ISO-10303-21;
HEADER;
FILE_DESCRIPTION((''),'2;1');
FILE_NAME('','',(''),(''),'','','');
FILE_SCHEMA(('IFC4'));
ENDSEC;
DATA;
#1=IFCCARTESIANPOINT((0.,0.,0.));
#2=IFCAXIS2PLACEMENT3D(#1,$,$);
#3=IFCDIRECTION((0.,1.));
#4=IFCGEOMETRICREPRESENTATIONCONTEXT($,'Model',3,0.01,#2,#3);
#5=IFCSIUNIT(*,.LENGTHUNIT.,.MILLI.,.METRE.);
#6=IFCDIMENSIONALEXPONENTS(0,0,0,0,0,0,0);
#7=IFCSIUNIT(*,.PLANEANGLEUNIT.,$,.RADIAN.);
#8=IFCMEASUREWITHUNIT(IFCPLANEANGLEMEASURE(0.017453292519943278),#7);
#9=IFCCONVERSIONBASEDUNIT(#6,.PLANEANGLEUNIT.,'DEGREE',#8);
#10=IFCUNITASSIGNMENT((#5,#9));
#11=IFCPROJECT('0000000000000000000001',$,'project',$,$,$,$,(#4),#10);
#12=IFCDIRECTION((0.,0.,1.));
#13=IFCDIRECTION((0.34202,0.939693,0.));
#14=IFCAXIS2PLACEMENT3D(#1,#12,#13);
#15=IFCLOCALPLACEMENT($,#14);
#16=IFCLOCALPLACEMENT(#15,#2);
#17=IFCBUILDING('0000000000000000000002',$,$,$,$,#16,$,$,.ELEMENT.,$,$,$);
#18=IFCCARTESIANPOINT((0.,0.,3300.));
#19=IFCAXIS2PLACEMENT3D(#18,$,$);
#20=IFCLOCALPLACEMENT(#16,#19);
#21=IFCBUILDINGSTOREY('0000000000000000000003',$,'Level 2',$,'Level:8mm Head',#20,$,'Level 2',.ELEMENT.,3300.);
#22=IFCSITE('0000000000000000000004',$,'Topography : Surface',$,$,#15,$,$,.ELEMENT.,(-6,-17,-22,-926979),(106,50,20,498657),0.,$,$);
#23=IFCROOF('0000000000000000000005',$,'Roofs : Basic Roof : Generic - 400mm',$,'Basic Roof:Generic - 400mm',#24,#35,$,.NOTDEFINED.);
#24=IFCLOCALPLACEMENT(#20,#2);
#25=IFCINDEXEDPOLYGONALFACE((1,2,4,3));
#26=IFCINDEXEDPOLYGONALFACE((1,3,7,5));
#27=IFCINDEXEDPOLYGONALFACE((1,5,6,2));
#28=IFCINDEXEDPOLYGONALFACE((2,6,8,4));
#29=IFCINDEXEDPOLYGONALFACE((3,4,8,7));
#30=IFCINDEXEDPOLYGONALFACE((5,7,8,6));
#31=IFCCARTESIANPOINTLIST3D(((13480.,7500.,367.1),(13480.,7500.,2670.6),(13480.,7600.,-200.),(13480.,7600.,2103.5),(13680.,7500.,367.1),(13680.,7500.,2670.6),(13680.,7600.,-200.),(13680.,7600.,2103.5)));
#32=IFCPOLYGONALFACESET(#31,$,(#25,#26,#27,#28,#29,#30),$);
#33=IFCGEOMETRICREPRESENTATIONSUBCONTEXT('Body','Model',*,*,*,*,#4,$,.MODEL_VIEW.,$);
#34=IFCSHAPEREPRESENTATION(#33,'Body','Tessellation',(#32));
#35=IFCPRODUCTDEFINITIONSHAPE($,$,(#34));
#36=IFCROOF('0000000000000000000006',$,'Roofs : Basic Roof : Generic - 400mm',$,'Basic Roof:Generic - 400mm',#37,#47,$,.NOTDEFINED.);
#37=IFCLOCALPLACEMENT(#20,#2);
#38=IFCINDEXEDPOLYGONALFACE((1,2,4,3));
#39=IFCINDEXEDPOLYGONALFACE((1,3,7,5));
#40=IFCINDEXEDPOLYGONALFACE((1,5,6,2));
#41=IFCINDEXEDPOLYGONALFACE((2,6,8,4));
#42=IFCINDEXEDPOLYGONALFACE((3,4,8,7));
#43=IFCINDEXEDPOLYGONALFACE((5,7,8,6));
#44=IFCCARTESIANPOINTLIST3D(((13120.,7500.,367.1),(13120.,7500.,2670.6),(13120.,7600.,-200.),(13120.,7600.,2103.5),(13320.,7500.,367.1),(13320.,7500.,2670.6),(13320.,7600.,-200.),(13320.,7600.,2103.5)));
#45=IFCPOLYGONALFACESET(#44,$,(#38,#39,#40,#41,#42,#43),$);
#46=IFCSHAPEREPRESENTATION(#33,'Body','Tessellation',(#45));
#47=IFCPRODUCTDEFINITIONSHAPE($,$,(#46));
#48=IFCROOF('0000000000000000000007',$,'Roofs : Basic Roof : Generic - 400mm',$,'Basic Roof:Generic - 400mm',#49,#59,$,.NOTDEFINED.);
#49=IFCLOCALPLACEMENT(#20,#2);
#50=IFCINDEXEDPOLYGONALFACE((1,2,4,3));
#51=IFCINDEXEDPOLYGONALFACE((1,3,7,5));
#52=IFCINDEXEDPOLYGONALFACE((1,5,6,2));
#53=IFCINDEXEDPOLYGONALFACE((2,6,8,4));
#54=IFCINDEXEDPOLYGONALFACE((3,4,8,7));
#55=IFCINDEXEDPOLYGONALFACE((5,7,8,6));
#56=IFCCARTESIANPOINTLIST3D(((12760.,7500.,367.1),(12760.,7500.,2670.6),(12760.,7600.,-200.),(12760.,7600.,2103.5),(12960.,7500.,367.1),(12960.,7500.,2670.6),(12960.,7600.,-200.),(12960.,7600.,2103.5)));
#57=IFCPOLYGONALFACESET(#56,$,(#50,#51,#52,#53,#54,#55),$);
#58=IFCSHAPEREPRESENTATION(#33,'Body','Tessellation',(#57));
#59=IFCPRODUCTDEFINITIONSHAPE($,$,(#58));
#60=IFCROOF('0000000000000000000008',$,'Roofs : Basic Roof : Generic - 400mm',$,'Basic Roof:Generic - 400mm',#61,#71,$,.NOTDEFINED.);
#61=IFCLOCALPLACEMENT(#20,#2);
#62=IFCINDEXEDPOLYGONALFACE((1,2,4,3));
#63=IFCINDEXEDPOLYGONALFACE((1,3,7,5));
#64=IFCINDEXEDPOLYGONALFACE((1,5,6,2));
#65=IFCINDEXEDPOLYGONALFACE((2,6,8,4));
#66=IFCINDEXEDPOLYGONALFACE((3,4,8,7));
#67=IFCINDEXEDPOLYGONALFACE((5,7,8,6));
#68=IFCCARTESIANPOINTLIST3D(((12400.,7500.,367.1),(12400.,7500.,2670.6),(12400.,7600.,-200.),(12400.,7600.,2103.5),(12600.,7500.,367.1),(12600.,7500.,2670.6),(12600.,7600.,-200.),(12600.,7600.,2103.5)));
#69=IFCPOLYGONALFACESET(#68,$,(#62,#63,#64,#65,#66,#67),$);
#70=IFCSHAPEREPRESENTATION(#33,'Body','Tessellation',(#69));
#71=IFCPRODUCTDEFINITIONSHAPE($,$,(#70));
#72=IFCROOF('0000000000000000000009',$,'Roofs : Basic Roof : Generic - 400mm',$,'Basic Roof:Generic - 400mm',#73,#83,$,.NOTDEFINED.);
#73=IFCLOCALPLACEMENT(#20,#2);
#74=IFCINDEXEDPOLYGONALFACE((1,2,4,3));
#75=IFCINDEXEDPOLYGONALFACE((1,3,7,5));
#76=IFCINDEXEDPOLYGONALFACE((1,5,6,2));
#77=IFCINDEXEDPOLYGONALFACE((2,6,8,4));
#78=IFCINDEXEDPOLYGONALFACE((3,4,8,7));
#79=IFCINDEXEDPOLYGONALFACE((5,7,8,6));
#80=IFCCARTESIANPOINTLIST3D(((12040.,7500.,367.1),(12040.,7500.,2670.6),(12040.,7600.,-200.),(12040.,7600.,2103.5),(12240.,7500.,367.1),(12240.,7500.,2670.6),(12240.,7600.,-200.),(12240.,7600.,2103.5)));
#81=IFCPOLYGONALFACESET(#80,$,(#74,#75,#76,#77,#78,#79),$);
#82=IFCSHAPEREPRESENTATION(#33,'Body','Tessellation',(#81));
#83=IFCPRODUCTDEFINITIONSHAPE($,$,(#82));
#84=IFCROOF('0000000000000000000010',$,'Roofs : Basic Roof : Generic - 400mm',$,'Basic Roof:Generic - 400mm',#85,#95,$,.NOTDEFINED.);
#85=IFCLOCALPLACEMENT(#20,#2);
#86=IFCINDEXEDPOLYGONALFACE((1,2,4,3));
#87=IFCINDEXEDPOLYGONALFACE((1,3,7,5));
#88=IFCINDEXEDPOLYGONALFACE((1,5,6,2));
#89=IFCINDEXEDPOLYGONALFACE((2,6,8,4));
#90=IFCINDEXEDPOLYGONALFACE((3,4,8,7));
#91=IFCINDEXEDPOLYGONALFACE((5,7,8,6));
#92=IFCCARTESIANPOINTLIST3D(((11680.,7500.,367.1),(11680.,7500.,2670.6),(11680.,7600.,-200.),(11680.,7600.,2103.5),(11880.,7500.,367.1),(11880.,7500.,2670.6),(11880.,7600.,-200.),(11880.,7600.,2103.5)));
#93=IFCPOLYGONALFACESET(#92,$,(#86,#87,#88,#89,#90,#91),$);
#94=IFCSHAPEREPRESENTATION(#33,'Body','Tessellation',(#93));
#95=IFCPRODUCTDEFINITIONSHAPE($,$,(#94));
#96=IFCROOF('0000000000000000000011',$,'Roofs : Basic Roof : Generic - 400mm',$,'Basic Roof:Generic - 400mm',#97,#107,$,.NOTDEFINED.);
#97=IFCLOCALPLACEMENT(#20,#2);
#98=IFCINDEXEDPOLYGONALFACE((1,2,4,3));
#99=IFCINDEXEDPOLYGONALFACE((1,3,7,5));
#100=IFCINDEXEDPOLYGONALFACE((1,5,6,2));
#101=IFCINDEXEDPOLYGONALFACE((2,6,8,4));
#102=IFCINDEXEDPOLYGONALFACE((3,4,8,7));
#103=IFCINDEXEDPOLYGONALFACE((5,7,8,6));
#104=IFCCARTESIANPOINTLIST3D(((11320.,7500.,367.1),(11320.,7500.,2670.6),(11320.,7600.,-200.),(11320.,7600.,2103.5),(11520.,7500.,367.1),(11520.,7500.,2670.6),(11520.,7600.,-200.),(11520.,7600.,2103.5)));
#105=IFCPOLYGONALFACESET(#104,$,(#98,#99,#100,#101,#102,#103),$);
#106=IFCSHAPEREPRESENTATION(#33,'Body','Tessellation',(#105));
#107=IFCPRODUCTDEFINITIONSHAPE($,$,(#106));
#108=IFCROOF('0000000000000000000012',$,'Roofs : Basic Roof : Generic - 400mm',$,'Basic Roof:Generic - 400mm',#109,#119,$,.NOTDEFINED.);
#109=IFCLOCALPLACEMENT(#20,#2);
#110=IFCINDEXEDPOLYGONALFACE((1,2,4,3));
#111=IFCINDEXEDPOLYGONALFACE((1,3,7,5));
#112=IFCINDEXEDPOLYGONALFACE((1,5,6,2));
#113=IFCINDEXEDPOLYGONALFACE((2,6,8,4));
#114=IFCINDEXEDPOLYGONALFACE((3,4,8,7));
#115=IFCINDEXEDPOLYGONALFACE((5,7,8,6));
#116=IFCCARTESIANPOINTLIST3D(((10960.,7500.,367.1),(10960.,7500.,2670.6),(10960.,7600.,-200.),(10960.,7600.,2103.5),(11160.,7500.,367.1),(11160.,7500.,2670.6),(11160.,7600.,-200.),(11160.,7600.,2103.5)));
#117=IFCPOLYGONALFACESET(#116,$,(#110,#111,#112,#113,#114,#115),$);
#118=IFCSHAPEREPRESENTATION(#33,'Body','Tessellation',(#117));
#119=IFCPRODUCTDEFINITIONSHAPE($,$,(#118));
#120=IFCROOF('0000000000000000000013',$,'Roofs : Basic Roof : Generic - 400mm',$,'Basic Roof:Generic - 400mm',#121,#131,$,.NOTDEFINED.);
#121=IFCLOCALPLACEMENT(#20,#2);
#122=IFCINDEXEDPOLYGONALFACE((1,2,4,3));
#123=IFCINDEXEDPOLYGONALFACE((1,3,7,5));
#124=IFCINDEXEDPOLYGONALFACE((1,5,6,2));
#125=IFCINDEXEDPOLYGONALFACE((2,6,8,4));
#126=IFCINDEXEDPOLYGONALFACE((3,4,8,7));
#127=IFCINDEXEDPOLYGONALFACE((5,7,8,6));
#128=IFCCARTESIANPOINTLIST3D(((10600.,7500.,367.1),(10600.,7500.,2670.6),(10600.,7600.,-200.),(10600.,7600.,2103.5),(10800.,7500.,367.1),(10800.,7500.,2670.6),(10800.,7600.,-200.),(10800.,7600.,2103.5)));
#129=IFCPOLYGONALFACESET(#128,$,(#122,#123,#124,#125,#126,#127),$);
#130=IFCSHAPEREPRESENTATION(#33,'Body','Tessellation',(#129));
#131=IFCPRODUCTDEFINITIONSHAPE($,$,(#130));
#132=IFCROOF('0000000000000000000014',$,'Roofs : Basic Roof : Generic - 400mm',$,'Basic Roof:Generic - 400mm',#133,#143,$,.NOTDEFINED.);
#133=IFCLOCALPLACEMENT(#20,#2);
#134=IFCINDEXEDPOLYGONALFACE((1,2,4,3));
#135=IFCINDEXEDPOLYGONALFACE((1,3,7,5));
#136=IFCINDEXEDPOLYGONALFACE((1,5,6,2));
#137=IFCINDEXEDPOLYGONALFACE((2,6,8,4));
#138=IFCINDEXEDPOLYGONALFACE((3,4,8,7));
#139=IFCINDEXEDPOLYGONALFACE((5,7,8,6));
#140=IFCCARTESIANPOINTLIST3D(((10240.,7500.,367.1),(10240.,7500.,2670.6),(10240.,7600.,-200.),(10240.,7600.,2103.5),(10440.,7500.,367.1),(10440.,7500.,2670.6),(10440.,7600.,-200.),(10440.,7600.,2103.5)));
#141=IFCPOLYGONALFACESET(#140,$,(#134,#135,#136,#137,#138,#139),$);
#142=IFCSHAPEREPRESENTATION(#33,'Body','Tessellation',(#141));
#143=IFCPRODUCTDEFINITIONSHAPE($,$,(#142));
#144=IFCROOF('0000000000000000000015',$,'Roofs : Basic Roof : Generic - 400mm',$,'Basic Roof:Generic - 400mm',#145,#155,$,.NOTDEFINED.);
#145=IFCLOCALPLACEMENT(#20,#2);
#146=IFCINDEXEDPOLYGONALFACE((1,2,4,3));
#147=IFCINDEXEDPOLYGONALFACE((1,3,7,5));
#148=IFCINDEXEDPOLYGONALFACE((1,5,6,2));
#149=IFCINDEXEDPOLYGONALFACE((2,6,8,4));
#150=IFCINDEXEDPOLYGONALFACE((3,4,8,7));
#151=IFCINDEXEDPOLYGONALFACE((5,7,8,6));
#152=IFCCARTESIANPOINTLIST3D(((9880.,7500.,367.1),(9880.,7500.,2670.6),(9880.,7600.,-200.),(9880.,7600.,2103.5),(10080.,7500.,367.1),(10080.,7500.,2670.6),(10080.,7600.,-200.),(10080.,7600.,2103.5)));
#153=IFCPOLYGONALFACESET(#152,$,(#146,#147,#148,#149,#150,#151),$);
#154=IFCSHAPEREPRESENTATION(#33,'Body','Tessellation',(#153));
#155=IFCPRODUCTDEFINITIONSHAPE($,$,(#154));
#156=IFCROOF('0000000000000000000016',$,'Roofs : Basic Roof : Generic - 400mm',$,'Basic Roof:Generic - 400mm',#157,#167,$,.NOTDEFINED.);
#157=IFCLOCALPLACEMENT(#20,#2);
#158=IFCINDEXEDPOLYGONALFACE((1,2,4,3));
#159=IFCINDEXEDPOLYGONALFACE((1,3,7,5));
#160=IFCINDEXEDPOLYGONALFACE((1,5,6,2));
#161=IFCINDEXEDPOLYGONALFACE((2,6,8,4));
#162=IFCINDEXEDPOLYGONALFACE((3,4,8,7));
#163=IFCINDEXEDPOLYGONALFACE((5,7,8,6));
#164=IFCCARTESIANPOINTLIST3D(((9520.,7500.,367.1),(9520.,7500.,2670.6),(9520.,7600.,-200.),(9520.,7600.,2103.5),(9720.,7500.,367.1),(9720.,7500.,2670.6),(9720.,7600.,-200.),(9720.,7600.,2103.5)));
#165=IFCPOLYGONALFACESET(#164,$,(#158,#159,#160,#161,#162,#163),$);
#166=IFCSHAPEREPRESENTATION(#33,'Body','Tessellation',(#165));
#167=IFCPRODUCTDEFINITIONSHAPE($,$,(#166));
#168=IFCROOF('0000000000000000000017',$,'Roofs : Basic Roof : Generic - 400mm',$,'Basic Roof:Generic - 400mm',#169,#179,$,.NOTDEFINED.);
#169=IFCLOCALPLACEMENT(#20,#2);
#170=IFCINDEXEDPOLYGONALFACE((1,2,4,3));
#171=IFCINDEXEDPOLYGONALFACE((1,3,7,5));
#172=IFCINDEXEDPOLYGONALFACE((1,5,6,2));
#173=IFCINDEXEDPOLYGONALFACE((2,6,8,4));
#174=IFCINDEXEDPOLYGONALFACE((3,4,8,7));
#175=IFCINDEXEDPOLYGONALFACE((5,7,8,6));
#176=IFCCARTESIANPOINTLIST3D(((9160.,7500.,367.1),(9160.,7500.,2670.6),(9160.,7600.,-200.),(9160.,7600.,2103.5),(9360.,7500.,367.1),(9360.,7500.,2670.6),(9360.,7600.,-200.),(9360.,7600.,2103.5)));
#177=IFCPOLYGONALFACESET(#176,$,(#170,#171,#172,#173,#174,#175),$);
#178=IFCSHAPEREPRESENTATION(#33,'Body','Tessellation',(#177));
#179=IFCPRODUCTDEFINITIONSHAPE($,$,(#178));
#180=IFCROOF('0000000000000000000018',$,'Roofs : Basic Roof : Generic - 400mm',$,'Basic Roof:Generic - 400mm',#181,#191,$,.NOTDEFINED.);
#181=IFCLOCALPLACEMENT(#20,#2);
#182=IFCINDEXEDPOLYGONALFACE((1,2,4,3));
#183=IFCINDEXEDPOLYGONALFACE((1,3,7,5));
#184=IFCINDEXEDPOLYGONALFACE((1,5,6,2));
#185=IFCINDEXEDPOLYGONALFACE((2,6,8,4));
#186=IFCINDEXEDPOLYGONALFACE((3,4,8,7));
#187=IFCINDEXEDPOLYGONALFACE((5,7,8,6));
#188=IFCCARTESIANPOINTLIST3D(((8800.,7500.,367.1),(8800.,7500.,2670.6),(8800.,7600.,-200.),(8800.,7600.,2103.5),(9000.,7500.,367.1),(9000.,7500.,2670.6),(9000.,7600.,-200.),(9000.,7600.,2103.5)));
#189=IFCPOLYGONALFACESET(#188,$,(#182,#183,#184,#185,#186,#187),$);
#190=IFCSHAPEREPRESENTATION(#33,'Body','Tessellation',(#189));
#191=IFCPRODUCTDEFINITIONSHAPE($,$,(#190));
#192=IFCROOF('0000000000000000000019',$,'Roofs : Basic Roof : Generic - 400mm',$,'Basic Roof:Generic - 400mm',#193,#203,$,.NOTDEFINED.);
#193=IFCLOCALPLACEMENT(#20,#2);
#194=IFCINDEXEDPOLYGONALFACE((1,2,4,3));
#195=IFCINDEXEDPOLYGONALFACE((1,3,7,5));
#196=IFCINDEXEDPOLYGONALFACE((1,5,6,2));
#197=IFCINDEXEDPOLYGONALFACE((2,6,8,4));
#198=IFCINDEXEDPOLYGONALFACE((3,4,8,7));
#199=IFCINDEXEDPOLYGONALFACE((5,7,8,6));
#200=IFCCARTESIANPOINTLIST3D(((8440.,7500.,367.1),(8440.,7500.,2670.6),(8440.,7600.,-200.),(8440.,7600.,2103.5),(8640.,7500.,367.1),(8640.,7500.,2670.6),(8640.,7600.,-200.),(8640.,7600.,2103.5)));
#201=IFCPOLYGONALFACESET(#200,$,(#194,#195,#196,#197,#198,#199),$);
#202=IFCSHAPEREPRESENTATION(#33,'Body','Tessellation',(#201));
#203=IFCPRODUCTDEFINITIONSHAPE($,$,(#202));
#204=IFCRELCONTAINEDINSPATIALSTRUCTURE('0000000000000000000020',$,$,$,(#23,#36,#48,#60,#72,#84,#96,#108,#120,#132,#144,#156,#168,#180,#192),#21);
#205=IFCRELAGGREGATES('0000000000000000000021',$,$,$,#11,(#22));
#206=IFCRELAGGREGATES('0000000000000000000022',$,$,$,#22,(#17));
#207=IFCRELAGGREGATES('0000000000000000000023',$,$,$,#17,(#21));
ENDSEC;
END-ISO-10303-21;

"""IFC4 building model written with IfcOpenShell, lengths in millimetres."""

from ifc_helpers import new_model, entity, si_unit, converted_unit, direction, frame, origin, place, context, subcontext, project, spatial, indexed_curve, outline, extrude, element, save


model = new_model("IFC4")

# Units and contexts
model_context = context("Model", 3, precision=0.01, world=origin(), true_north=direction((0.0, 1.0)))
body_context = subcontext(model_context, "Body", "Model", "MODEL_VIEW")
ifc_project = project(units=[si_unit("LENGTHUNIT", "METRE", prefix="MILLI"), converted_unit("PLANEANGLEUNIT", "DEGREE", entity("IfcPlaneAngleMeasure", 0.017453292519943278), si_unit("PLANEANGLEUNIT", "RADIAN"), dimensions=[0, 0, 0, 0, 0, 0, 0])], contexts=[model_context])

# Site, building, storey
site_placement = place(None, frame((0.0, 0.0, 0.0), z_axis=(0.0, 0.0, 1.0), x_axis=(0.34202, 0.939693, 0.0)))
site = spatial("IfcSite", under=ifc_project, at=site_placement, Name="Topography : Surface", CompositionType="ELEMENT", RefLatitude=(-6, -17, -22, -926979), RefLongitude=(106, 50, 20, 498657), RefElevation=0.0)
building_placement = place(site_placement, origin())
building = spatial("IfcBuilding", under=site, at=building_placement, CompositionType="ELEMENT")
storey_placement = place(building_placement, frame((0.0, 0.0, 3300.0)))
storey = spatial("IfcBuildingStorey", under=building, at=storey_placement, Name="Level 2", ObjectType="Level:8mm Head", LongName="Level 2", CompositionType="ELEMENT", Elevation=3300.0)

# Roofs
roof_1_placement = place(storey_placement, frame((13480.0, 7500.0, -200.0)))
element("IfcRoof", 1, at=roof_1_placement, inside=storey, Name="Roofs : Basic Roof : Generic - 400mm", ObjectType="Basic Roof:Generic - 400mm", PredefinedType="NOTDEFINED", context=body_context, shape_type="SweptSolid", body=[
    extrude(outline(indexed_curve([(100.0, 287.9), (-100.0, 287.9), (-100.0, -287.9), (100.0, -287.9), (100.0, 287.9)], self_intersect=False)), frame((100.0, 50.0, 283.6), z_axis=(0.0, 0.984808, 0.173648), x_axis=(1.0, 0.0, 0.0)), (0.0, -0.984808, 0.173648), 2303.5),
])
roof_2_placement = place(storey_placement, frame((13120.0, 7500.0, -200.0)))
element("IfcRoof", 2, at=roof_2_placement, inside=storey, Name="Roofs : Basic Roof : Generic - 400mm", ObjectType="Basic Roof:Generic - 400mm", PredefinedType="NOTDEFINED", context=body_context, shape_type="SweptSolid", body=[
    extrude(outline(indexed_curve([(100.0, 287.9), (-100.0, 287.9), (-100.0, -287.9), (100.0, -287.9), (100.0, 287.9)], self_intersect=False)), frame((100.0, 50.0, 283.6), z_axis=(0.0, 0.984808, 0.173648), x_axis=(1.0, 0.0, 0.0)), (0.0, -0.984808, 0.173648), 2303.5),
])
roof_3_placement = place(storey_placement, frame((12760.0, 7500.0, -200.0)))
element("IfcRoof", 3, at=roof_3_placement, inside=storey, Name="Roofs : Basic Roof : Generic - 400mm", ObjectType="Basic Roof:Generic - 400mm", PredefinedType="NOTDEFINED", context=body_context, shape_type="SweptSolid", body=[
    extrude(outline(indexed_curve([(100.0, 287.9), (-100.0, 287.9), (-100.0, -287.9), (100.0, -287.9), (100.0, 287.9)], self_intersect=False)), frame((100.0, 50.0, 283.6), z_axis=(0.0, 0.984808, 0.173648), x_axis=(1.0, 0.0, 0.0)), (0.0, -0.984808, 0.173648), 2303.5),
])
roof_4_placement = place(storey_placement, frame((12400.0, 7500.0, -200.0)))
element("IfcRoof", 4, at=roof_4_placement, inside=storey, Name="Roofs : Basic Roof : Generic - 400mm", ObjectType="Basic Roof:Generic - 400mm", PredefinedType="NOTDEFINED", context=body_context, shape_type="SweptSolid", body=[
    extrude(outline(indexed_curve([(100.0, 287.9), (-100.0, 287.9), (-100.0, -287.9), (100.0, -287.9), (100.0, 287.9)], self_intersect=False)), frame((100.0, 50.0, 283.6), z_axis=(0.0, 0.984808, 0.173648), x_axis=(1.0, 0.0, 0.0)), (0.0, -0.984808, 0.173648), 2303.5),
])
for number, where, name in (
    (5, (12040.0, 7500.0, -200.0), "Roofs : Basic Roof : Generic - 400mm"),
    (6, (11680.0, 7500.0, -200.0), "Roofs : Basic Roof : Generic - 400mm"),
    (7, (11320.0, 7500.0, -200.0), "Roofs : Basic Roof : Generic - 400mm"),
):
    element("IfcRoof", number, at=place(storey_placement, frame(where)), inside=storey, Name=name, ObjectType="Basic Roof:Generic - 400mm", PredefinedType="NOTDEFINED", context=body_context, shape_type="SweptSolid", body=[
        extrude(outline(indexed_curve([(100.0, 287.9), (-100.0, 287.9), (-100.0, -287.9), (100.0, -287.9), (100.0, 287.9)], self_intersect=False)), frame((100.0, 50.0, 283.6), z_axis=(0.0, 0.984808, 0.173648), x_axis=(1.0, 0.0, 0.0)), (0.0, -0.984808, 0.173648), 2303.5),
    ])
roof_5_placement = place(storey_placement, frame((10960.0, 7500.0, -200.0)))
element("IfcRoof", 8, at=roof_5_placement, inside=storey, Name="Roofs : Basic Roof : Generic - 400mm", ObjectType="Basic Roof:Generic - 400mm", PredefinedType="NOTDEFINED", context=body_context, shape_type="SweptSolid", body=[
    extrude(outline(indexed_curve([(100.0, 287.9), (-100.0, 287.9), (-100.0, -287.9), (100.0, -287.9), (100.0, 287.9)], self_intersect=False)), frame((100.0, 50.0, 283.6), z_axis=(0.0, 0.984808, 0.173648), x_axis=(1.0, 0.0, 0.0)), (0.0, -0.984808, 0.173648), 2303.5),
])
for number, where, name in (
    (9, (10600.0, 7500.0, -200.0), "Roofs : Basic Roof : Generic - 400mm"),
    (10, (10240.0, 7500.0, -200.0), "Roofs : Basic Roof : Generic - 400mm"),
    (11, (9880.0, 7500.0, -200.0), "Roofs : Basic Roof : Generic - 400mm"),
):
    element("IfcRoof", number, at=place(storey_placement, frame(where)), inside=storey, Name=name, ObjectType="Basic Roof:Generic - 400mm", PredefinedType="NOTDEFINED", context=body_context, shape_type="SweptSolid", body=[
        extrude(outline(indexed_curve([(100.0, 287.9), (-100.0, 287.9), (-100.0, -287.9), (100.0, -287.9), (100.0, 287.9)], self_intersect=False)), frame((100.0, 50.0, 283.6), z_axis=(0.0, 0.984808, 0.173648), x_axis=(1.0, 0.0, 0.0)), (0.0, -0.984808, 0.173648), 2303.5),
    ])
roof_6_placement = place(storey_placement, frame((9520.0, 7500.0, -200.0)))
element("IfcRoof", 12, at=roof_6_placement, inside=storey, Name="Roofs : Basic Roof : Generic - 400mm", ObjectType="Basic Roof:Generic - 400mm", PredefinedType="NOTDEFINED", context=body_context, shape_type="SweptSolid", body=[
    extrude(outline(indexed_curve([(100.0, 287.9), (-100.0, 287.9), (-100.0, -287.9), (100.0, -287.9), (100.0, 287.9)], self_intersect=False)), frame((100.0, 50.0, 283.6), z_axis=(0.0, 0.984808, 0.173648), x_axis=(1.0, 0.0, 0.0)), (0.0, -0.984808, 0.173648), 2303.5),
])
for number, where, name in (
    (13, (9160.0, 7500.0, -200.0), "Roofs : Basic Roof : Generic - 400mm"),
    (14, (8800.0, 7500.0, -200.0), "Roofs : Basic Roof : Generic - 400mm"),
    (15, (8440.0, 7500.0, -200.0), "Roofs : Basic Roof : Generic - 400mm"),
):
    element("IfcRoof", number, at=place(storey_placement, frame(where)), inside=storey, Name=name, ObjectType="Basic Roof:Generic - 400mm", PredefinedType="NOTDEFINED", context=body_context, shape_type="SweptSolid", body=[
        extrude(outline(indexed_curve([(100.0, 287.9), (-100.0, 287.9), (-100.0, -287.9), (100.0, -287.9), (100.0, 287.9)], self_intersect=False)), frame((100.0, 50.0, 283.6), z_axis=(0.0, 0.984808, 0.173648), x_axis=(1.0, 0.0, 0.0)), (0.0, -0.984808, 0.173648), 2303.5),
    ])

save(model, "model.ifc")
